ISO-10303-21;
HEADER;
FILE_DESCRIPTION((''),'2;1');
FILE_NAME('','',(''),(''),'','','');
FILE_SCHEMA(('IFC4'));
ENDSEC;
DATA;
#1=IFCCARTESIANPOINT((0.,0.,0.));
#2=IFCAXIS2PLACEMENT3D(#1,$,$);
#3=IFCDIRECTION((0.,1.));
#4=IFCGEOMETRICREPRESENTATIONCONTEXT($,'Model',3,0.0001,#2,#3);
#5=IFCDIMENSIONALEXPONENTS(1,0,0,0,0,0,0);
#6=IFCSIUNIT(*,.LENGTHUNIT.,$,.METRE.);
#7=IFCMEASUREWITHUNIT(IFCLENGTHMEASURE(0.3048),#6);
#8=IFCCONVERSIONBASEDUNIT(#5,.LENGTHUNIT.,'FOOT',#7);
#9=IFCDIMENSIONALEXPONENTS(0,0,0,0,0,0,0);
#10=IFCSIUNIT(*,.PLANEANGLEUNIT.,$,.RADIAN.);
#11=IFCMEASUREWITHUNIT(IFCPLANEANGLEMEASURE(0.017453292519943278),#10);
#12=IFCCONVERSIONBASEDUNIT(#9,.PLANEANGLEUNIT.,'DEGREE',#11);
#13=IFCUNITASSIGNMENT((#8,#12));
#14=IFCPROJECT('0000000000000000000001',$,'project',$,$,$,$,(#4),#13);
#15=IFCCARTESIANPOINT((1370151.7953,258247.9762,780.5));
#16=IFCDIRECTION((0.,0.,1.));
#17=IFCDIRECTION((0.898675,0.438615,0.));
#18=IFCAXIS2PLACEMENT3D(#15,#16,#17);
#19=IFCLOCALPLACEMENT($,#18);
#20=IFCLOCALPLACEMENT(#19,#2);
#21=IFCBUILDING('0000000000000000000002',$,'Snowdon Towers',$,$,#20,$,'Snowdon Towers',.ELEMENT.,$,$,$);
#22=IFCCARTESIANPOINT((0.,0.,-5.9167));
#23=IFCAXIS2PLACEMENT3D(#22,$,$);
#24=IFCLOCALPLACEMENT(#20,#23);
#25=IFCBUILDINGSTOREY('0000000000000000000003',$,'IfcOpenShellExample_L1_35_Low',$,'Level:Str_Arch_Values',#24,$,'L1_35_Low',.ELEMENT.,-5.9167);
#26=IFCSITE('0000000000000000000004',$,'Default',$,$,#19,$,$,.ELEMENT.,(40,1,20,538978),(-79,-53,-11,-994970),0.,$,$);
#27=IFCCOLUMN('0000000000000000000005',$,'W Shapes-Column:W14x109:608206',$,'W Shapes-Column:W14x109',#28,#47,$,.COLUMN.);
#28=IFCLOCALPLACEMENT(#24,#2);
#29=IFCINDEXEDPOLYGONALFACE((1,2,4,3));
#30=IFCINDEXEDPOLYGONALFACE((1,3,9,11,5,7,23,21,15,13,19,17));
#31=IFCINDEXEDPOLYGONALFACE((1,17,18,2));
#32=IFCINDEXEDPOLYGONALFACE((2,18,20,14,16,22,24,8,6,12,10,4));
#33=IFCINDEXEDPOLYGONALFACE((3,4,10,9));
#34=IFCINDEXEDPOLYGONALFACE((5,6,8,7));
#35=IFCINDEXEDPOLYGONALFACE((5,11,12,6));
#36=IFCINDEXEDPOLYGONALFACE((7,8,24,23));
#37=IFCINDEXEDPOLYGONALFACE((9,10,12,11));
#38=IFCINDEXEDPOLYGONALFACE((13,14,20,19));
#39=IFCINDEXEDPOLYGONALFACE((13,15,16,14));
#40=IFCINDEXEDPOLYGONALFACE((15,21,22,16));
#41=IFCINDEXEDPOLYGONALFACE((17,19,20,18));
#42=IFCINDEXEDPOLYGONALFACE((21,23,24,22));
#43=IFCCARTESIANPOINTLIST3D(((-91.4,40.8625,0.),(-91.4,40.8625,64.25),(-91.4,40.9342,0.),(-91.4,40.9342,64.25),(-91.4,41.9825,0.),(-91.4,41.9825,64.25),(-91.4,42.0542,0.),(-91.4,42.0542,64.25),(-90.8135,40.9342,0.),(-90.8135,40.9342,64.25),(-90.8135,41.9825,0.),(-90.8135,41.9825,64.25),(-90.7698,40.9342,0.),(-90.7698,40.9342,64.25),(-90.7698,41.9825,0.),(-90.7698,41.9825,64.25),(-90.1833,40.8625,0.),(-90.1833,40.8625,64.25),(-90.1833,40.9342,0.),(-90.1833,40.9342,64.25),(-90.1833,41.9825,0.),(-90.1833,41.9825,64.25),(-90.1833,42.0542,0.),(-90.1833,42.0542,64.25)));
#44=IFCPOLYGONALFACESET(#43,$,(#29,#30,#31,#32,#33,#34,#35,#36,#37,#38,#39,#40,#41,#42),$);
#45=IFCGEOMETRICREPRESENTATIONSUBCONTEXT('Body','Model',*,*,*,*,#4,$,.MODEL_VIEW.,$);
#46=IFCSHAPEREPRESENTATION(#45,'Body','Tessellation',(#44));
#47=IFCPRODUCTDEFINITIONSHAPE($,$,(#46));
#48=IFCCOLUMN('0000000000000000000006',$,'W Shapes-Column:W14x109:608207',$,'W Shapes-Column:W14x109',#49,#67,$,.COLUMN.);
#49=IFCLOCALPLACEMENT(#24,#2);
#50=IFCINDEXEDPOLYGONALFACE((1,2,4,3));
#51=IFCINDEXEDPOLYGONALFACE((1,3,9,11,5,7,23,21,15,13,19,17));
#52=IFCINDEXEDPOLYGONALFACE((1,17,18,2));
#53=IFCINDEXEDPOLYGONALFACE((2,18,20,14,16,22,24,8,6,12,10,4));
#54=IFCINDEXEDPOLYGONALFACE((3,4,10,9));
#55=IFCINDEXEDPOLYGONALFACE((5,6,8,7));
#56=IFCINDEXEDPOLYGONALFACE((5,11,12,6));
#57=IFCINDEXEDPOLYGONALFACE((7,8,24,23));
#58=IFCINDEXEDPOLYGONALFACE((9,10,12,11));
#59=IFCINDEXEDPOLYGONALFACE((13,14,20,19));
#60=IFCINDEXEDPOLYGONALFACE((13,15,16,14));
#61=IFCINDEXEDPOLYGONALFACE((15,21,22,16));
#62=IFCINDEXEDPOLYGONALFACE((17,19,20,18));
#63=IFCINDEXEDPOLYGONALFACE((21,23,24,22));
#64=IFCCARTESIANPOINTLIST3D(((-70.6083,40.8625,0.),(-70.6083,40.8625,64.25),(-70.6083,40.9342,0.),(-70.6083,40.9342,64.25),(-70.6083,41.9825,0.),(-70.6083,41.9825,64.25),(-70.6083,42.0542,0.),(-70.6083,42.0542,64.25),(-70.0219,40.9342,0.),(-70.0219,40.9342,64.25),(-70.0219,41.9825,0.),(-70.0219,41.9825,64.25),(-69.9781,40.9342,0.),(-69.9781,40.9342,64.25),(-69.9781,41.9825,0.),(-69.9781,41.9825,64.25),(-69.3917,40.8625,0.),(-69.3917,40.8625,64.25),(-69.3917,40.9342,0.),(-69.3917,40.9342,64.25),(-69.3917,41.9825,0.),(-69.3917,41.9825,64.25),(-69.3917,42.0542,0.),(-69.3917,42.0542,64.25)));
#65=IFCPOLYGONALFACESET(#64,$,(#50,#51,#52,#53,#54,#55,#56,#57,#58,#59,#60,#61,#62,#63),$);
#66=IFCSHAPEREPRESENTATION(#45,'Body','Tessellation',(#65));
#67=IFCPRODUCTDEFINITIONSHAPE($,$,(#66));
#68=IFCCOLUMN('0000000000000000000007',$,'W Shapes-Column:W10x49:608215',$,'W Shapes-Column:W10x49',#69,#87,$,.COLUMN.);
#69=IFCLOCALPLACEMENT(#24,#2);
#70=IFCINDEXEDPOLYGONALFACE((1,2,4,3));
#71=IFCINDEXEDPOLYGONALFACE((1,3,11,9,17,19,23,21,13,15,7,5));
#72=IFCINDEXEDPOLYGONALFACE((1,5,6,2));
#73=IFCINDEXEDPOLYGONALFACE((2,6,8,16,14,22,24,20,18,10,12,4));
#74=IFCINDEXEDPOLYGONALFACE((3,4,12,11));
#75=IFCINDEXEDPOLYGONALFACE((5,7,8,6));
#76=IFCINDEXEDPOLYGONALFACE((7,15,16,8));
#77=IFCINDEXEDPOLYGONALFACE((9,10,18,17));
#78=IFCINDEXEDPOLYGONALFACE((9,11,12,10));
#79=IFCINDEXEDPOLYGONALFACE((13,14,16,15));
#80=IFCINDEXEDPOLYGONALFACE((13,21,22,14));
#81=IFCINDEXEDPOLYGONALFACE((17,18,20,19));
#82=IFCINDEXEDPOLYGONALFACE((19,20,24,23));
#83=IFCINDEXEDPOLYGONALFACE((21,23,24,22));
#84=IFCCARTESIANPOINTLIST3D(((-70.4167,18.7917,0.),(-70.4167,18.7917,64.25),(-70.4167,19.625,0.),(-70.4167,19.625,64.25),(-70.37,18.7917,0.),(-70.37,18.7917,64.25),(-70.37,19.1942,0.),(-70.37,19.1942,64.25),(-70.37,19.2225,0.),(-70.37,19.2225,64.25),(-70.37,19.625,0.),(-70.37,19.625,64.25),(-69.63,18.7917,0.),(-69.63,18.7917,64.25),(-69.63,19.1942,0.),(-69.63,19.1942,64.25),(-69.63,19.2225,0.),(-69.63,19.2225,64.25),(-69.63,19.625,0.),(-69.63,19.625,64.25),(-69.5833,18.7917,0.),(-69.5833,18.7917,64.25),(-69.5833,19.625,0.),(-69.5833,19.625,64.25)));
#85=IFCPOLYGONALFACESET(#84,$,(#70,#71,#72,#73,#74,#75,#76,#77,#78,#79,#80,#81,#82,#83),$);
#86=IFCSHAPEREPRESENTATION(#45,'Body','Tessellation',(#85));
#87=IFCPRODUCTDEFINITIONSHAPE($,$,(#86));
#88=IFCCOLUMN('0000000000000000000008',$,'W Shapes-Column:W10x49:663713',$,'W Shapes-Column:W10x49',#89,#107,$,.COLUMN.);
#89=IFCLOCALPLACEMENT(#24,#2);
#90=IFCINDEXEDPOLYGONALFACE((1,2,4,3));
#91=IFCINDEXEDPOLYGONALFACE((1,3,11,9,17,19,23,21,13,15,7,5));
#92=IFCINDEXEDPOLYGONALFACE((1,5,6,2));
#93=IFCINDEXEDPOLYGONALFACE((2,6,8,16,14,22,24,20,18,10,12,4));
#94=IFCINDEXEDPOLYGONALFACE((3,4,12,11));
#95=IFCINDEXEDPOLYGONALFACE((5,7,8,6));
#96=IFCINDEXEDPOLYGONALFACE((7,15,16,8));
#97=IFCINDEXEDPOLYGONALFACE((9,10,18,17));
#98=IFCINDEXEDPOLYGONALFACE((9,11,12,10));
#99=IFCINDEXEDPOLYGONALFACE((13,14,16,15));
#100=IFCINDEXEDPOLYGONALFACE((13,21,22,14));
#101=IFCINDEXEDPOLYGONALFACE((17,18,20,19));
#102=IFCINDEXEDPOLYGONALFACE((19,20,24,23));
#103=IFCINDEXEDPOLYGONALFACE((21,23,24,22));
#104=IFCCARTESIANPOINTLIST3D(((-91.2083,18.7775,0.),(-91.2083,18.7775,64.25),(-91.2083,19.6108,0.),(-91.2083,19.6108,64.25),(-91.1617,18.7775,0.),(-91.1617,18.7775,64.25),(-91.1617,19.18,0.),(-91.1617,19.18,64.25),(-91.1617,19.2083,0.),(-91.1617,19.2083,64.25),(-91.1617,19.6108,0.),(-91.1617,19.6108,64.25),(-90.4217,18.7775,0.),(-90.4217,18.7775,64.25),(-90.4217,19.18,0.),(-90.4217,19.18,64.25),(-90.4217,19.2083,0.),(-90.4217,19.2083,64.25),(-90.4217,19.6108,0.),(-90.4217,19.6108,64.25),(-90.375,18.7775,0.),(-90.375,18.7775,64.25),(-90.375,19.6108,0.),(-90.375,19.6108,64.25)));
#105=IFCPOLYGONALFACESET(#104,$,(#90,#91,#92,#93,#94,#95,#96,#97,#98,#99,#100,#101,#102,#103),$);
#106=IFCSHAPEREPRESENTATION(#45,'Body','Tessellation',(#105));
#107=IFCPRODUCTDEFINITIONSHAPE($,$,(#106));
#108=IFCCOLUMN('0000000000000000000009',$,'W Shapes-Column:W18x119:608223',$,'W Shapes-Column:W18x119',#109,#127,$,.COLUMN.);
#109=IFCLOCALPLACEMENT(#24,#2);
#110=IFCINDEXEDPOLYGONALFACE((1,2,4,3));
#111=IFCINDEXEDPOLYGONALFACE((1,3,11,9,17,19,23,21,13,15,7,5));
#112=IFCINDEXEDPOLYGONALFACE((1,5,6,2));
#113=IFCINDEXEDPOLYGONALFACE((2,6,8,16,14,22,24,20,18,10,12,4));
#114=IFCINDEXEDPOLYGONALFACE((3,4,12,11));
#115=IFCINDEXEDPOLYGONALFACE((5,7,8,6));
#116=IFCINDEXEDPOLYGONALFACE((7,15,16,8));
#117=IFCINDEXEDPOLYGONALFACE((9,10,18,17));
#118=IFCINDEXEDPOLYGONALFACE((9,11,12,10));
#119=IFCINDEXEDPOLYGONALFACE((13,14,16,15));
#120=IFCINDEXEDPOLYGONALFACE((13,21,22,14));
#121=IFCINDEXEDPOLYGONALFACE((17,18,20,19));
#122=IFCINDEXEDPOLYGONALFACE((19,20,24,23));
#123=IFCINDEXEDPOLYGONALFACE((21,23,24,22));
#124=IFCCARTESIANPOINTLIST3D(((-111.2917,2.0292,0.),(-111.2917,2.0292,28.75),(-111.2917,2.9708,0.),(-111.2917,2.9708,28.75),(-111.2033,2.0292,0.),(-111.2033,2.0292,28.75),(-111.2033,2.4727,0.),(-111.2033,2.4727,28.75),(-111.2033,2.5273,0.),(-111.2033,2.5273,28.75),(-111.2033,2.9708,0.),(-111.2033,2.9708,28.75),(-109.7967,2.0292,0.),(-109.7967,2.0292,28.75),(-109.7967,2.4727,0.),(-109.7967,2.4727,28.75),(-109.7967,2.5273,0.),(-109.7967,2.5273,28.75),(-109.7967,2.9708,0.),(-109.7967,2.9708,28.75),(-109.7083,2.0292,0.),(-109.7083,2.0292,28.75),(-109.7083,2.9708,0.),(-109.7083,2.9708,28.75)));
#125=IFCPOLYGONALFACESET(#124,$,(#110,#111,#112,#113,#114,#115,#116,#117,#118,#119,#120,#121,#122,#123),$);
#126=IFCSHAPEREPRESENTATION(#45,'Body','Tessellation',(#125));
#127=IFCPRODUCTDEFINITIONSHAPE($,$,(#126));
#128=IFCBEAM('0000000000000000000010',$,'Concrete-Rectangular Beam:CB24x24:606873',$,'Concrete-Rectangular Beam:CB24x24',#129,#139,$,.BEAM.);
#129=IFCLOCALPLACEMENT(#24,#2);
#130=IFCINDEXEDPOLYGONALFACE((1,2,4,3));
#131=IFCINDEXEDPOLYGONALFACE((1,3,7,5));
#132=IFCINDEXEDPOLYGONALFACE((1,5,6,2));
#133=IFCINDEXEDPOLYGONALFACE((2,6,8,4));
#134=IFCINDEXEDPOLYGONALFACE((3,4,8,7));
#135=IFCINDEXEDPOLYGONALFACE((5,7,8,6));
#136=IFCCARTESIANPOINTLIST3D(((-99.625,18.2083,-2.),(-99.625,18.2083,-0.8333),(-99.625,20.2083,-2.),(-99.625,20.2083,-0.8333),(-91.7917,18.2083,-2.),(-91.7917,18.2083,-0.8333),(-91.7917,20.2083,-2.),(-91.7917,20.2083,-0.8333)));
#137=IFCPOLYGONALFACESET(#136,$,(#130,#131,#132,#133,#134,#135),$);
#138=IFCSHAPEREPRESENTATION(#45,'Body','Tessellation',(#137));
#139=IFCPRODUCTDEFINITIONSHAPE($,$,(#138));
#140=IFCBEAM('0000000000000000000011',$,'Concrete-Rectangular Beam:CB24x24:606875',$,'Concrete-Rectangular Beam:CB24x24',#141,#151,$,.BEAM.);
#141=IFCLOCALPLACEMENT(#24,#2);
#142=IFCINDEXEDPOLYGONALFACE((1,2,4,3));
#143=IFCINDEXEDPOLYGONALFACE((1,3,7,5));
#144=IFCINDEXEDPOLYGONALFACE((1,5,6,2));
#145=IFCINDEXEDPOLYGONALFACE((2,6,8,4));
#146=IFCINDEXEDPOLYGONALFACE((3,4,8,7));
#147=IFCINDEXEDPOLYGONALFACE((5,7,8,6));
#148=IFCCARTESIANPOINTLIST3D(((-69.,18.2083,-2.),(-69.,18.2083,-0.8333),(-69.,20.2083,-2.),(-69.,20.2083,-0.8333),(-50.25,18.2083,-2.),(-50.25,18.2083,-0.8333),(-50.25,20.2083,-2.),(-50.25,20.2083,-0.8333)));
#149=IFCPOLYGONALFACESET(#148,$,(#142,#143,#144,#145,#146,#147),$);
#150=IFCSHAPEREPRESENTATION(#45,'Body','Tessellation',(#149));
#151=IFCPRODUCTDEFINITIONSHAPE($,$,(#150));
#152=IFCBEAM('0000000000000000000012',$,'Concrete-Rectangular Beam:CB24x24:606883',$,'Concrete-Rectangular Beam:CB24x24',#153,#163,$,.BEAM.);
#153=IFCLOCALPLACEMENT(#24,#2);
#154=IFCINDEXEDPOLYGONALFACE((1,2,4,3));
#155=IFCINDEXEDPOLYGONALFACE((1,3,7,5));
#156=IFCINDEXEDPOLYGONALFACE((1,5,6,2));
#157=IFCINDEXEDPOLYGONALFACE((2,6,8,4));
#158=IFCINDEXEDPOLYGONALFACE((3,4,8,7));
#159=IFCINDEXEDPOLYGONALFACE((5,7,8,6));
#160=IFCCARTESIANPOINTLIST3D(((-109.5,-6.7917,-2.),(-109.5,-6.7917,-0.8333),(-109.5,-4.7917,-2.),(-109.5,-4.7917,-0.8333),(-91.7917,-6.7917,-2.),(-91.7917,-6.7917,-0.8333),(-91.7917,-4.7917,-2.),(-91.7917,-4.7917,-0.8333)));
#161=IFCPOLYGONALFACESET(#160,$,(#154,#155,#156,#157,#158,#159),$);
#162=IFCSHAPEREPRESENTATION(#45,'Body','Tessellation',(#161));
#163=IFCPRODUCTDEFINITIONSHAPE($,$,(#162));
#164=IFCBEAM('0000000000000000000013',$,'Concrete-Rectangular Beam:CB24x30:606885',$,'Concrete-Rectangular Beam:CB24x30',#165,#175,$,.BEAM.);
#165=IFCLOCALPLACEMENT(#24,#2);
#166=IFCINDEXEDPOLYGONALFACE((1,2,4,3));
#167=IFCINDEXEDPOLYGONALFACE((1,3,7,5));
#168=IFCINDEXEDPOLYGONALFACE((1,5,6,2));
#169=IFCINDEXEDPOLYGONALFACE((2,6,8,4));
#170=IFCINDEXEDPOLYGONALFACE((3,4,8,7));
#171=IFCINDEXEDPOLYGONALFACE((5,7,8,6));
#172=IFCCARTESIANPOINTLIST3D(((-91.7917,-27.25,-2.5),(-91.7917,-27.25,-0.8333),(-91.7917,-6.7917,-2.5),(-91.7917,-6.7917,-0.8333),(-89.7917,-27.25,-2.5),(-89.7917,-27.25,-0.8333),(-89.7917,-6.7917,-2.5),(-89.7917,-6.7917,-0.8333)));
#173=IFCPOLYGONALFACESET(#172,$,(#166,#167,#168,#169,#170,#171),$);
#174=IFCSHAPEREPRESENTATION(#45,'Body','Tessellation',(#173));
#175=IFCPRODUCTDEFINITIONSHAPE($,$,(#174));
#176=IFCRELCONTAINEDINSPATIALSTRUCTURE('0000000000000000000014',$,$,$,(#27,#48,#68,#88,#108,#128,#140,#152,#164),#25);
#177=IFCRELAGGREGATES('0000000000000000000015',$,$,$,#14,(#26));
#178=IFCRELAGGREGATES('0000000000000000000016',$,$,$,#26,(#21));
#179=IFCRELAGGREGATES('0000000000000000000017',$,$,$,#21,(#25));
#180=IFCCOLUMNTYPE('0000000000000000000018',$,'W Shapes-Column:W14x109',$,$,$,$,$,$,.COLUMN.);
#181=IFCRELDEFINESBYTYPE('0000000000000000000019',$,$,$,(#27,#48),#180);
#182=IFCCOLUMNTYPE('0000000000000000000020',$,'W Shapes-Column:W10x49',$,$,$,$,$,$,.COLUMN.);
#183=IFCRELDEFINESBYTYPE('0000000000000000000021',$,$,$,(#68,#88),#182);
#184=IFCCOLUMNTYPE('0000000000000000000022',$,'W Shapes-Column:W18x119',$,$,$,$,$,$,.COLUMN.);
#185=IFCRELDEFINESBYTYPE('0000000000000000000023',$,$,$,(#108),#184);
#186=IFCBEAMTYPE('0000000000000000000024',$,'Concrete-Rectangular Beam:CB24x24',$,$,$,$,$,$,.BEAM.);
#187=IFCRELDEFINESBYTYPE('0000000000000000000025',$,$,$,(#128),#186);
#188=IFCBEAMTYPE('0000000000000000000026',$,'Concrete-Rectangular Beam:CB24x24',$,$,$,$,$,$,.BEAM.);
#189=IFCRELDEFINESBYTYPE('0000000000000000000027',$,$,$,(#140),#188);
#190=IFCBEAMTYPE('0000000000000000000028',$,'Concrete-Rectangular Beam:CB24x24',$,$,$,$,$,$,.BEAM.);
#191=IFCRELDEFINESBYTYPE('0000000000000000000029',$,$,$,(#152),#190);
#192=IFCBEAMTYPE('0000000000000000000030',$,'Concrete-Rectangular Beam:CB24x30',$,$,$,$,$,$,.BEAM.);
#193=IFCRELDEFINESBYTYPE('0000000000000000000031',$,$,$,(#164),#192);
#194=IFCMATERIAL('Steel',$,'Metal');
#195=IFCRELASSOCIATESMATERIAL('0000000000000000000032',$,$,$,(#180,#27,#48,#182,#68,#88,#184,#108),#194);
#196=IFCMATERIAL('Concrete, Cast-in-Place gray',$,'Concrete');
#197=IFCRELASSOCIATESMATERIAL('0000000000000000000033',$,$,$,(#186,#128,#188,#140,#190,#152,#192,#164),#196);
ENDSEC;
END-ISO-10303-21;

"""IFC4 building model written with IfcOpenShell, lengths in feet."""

from ifc_helpers import new_model, entity, si_unit, converted_unit, direction, frame, origin, place, context, subcontext, project, spatial, indexed_curve, outline, extrude, source, transform, mapped, material, type_object, type_shapes, element, save


model = new_model("IFC4")

# Units and contexts
model_context = context("Model", 3, precision=0.0001, world=origin(), true_north=direction((0.0, 1.0)))
body_context = subcontext(model_context, "Body", "Model", "MODEL_VIEW")
ifc_project = project(units=[converted_unit("LENGTHUNIT", "FOOT", entity("IfcLengthMeasure", 0.3048), si_unit("LENGTHUNIT", "METRE"), dimensions=[1, 0, 0, 0, 0, 0, 0]), converted_unit("PLANEANGLEUNIT", "DEGREE", entity("IfcPlaneAngleMeasure", 0.017453292519943278), si_unit("PLANEANGLEUNIT", "RADIAN"), dimensions=[0, 0, 0, 0, 0, 0, 0])], contexts=[model_context])

# Site, building, storey
site_placement = place(None, frame((1370151.7953, 258247.9762, 780.5), z_axis=(0.0, 0.0, 1.0), x_axis=(0.898675, 0.438615, 0.0)))
site = spatial("IfcSite", under=ifc_project, at=site_placement, Name="Default", CompositionType="ELEMENT", RefLatitude=(40, 1, 20, 538978), RefLongitude=(-79, -53, -11, -994970), RefElevation=0.0)
building_placement = place(site_placement, origin())
building = spatial("IfcBuilding", under=site, at=building_placement, Name="Snowdon Towers", LongName="Snowdon Towers", CompositionType="ELEMENT")
storey_placement = place(building_placement, frame((0.0, 0.0, -5.9167)))
storey = spatial("IfcBuildingStorey", under=building, at=storey_placement, Name="IfcOpenShellExample_L1_35_Low", ObjectType="Level:Str_Arch_Values", LongName="L1_35_Low", CompositionType="ELEMENT", Elevation=-5.9167)

# Columns
ifc_material_1 = material(Name="Steel", Category="Metal")
column_type_1 = type_object("IfcColumnType", Name="W Shapes-Column:W14x109", PredefinedType="COLUMN", material=ifc_material_1)
shared_shape_1 = source(origin(), body_context, "Body", "SweptSolid", [
    extrude(outline(indexed_curve([(-0.6083, -0.5958), (0.6083, -0.5958), (0.6083, -0.5242), (0.0219, -0.5242), (0.0219, 0.5242), (0.6083, 0.5242), (0.6083, 0.5958), (-0.6083, 0.5958), (-0.6083, 0.5242), (-0.0219, 0.5242), (-0.0219, -0.5242), (-0.6083, -0.5242), (-0.6083, -0.5958)], self_intersect=False)), frame((0.0, 0.0, -5.9167), z_axis=(0.0, 0.0, 1.0), x_axis=(-1.0, 0.0, 0.0)), (0.0, 0.0, 1.0), 64.25),
])
type_shapes(column_type_1, [shared_shape_1])
for number, where, z_axis, x_axis, name in (
    (1, (-90.7917, 41.4583, 5.9167), (0.0, 0.0, 1.0), (-1.0, 0.0, 0.0), "W Shapes-Column:W14x109:608206"),
    (2, (-70.0, 41.4583, 5.9167), (0.0, 0.0, 1.0), (-1.0, 0.0, 0.0), "W Shapes-Column:W14x109:608207"),
):
    element("IfcColumn", number, at=place(storey_placement, frame(where, z_axis=z_axis, x_axis=x_axis)), inside=storey, type_object=column_type_1, material=ifc_material_1, Name=name, ObjectType="W Shapes-Column:W14x109", PredefinedType="COLUMN", context=body_context, shape_type="MappedRepresentation", body=[
        mapped(shared_shape_1, transform((0.0, 0.0, 0.0), scale=1.0)),
    ])
column_type_2 = type_object("IfcColumnType", Name="W Shapes-Column:W10x49", PredefinedType="COLUMN", material=ifc_material_1)
shared_shape_2 = source(origin(), body_context, "Body", "SweptSolid", [
    extrude(outline(indexed_curve([(-0.4167, -0.4167), (0.4167, -0.4167), (0.4167, -0.37), (0.0142, -0.37), (0.0142, 0.37), (0.4167, 0.37), (0.4167, 0.4167), (-0.4167, 0.4167), (-0.4167, 0.37), (-0.0142, 0.37), (-0.0142, -0.37), (-0.4167, -0.37), (-0.4167, -0.4167)], self_intersect=False)), frame((0.0, 0.0, -5.9167), z_axis=(0.0, 0.0, 1.0), x_axis=(-1.0, 0.0, 0.0)), (0.0, 0.0, 1.0), 64.25),
])
type_shapes(column_type_2, [shared_shape_2])
for number, where, z_axis, x_axis, name in (
    (3, (-70.0, 19.2083, 5.9167), (0.0, 0.0, 1.0), (0.0, 1.0, 0.0), "W Shapes-Column:W10x49:608215"),
    (4, (-90.7917, 19.1942, 5.9167), (0.0, 0.0, 1.0), (0.0, 1.0, 0.0), "W Shapes-Column:W10x49:663713"),
):
    element("IfcColumn", number, at=place(storey_placement, frame(where, z_axis=z_axis, x_axis=x_axis)), inside=storey, type_object=column_type_2, material=ifc_material_1, Name=name, ObjectType="W Shapes-Column:W10x49", PredefinedType="COLUMN", context=body_context, shape_type="MappedRepresentation", body=[
        mapped(shared_shape_2, transform((0.0, 0.0, 0.0), scale=1.0)),
    ])
column_type_3 = type_object("IfcColumnType", Name="W Shapes-Column:W18x119", PredefinedType="COLUMN", material=ifc_material_1)
shared_shape_3 = source(origin(), body_context, "Body", "SweptSolid", [
    extrude(outline(indexed_curve([(-0.4708, -0.7917), (0.4708, -0.7917), (0.4708, -0.7033), (0.0273, -0.7033), (0.0273, 0.7033), (0.4708, 0.7033), (0.4708, 0.7917), (-0.4708, 0.7917), (-0.4708, 0.7033), (-0.0273, 0.7033), (-0.0273, -0.7033), (-0.4708, -0.7033), (-0.4708, -0.7917)], self_intersect=False)), frame((0.0, 0.0, -5.9167), z_axis=(0.0, 0.0, 1.0), x_axis=(-1.0, 0.0, 0.0)), (0.0, 0.0, 1.0), 28.75),
])
type_shapes(column_type_3, [shared_shape_3])
column_placement = place(storey_placement, frame((-110.5, 2.5, 5.9167), z_axis=(0.0, 0.0, 1.0), x_axis=(0.0, -1.0, 0.0)))
element("IfcColumn", 5, at=column_placement, inside=storey, type_object=column_type_3, material=ifc_material_1, Name="W Shapes-Column:W18x119:608223", ObjectType="W Shapes-Column:W18x119", PredefinedType="COLUMN", context=body_context, shape_type="MappedRepresentation", body=[
    mapped(shared_shape_3, transform((0.0, 0.0, 0.0), scale=1.0)),
])

# Beams
ifc_material_2 = material(Name="Concrete, Cast-in-Place gray", Category="Concrete")
beam_type_1 = type_object("IfcBeamType", Name="Concrete-Rectangular Beam:CB24x24", PredefinedType="BEAM", material=ifc_material_2)
shared_shape_4 = source(origin(), body_context, "Body", "SweptSolid", [
    extrude(outline(indexed_curve([(-0.5833, -1.0), (0.5833, -1.0), (0.5833, 1.0), (-0.5833, 1.0), (-0.5833, -1.0)], self_intersect=False)), frame((-99.625, 19.2083, -7.3333), z_axis=(1.0, 0.0, 0.0), x_axis=(0.0, 0.0, -1.0)), (0.0, 0.0, 1.0), 7.8333),
])
type_shapes(beam_type_1, [shared_shape_4])
beam_1_placement = place(storey_placement, frame((0.0, 0.0, 5.9167)))
element("IfcBeam", 6, at=beam_1_placement, inside=storey, type_object=beam_type_1, material=ifc_material_2, Name="Concrete-Rectangular Beam:CB24x24:606873", ObjectType="Concrete-Rectangular Beam:CB24x24", PredefinedType="BEAM", context=body_context, shape_type="MappedRepresentation", body=[
    mapped(shared_shape_4, transform((0.0, 0.0, 0.0), scale=1.0)),
])
beam_type_2 = type_object("IfcBeamType", Name="Concrete-Rectangular Beam:CB24x24", PredefinedType="BEAM", material=ifc_material_2)
shared_shape_5 = source(origin(), body_context, "Body", "SweptSolid", [
    extrude(outline(indexed_curve([(-0.5833, -1.0), (0.5833, -1.0), (0.5833, 1.0), (-0.5833, 1.0), (-0.5833, -1.0)], self_intersect=False)), frame((-69.0, 19.2083, -7.3333), z_axis=(1.0, 0.0, 0.0), x_axis=(0.0, 0.0, -1.0)), (0.0, 0.0, 1.0), 18.75),
])
type_shapes(beam_type_2, [shared_shape_5])
beam_2_placement = place(storey_placement, frame((0.0, 0.0, 5.9167)))
element("IfcBeam", 7, at=beam_2_placement, inside=storey, type_object=beam_type_2, material=ifc_material_2, Name="Concrete-Rectangular Beam:CB24x24:606875", ObjectType="Concrete-Rectangular Beam:CB24x24", PredefinedType="BEAM", context=body_context, shape_type="MappedRepresentation", body=[
    mapped(shared_shape_5, transform((0.0, 0.0, 0.0), scale=1.0)),
])
beam_type_3 = type_object("IfcBeamType", Name="Concrete-Rectangular Beam:CB24x24", PredefinedType="BEAM", material=ifc_material_2)
shared_shape_6 = source(origin(), body_context, "Body", "SweptSolid", [
    extrude(outline(indexed_curve([(-0.5833, -1.0), (0.5833, -1.0), (0.5833, 1.0), (-0.5833, 1.0), (-0.5833, -1.0)], self_intersect=False)), frame((-109.5, -5.7917, -7.3333), z_axis=(1.0, 0.0, 0.0), x_axis=(0.0, 0.0, -1.0)), (0.0, 0.0, 1.0), 17.7083),
])
type_shapes(beam_type_3, [shared_shape_6])
beam_3_placement = place(storey_placement, frame((0.0, 0.0, 5.9167)))
element("IfcBeam", 8, at=beam_3_placement, inside=storey, type_object=beam_type_3, material=ifc_material_2, Name="Concrete-Rectangular Beam:CB24x24:606883", ObjectType="Concrete-Rectangular Beam:CB24x24", PredefinedType="BEAM", context=body_context, shape_type="MappedRepresentation", body=[
    mapped(shared_shape_6, transform((0.0, 0.0, 0.0), scale=1.0)),
])
beam_type_4 = type_object("IfcBeamType", Name="Concrete-Rectangular Beam:CB24x30", PredefinedType="BEAM", material=ifc_material_2)
shared_shape_7 = source(origin(), body_context, "Body", "SweptSolid", [
    extrude(outline(indexed_curve([(-1.0, -0.8333), (1.0, -0.8333), (1.0, 0.8333), (-1.0, 0.8333), (-1.0, -0.8333)], self_intersect=False)), frame((-90.7917, -27.25, -7.5833), z_axis=(0.0, 1.0, 0.0), x_axis=(-1.0, 0.0, 0.0)), (0.0, 0.0, 1.0), 20.4583),
])
type_shapes(beam_type_4, [shared_shape_7])
beam_4_placement = place(storey_placement, frame((0.0, 0.0, 5.9167)))
element("IfcBeam", 9, at=beam_4_placement, inside=storey, type_object=beam_type_4, material=ifc_material_2, Name="Concrete-Rectangular Beam:CB24x30:606885", ObjectType="Concrete-Rectangular Beam:CB24x30", PredefinedType="BEAM", context=body_context, shape_type="MappedRepresentation", body=[
    mapped(shared_shape_7, transform((0.0, 0.0, 0.0), scale=1.0)),
])

save(model, "model.ifc")
